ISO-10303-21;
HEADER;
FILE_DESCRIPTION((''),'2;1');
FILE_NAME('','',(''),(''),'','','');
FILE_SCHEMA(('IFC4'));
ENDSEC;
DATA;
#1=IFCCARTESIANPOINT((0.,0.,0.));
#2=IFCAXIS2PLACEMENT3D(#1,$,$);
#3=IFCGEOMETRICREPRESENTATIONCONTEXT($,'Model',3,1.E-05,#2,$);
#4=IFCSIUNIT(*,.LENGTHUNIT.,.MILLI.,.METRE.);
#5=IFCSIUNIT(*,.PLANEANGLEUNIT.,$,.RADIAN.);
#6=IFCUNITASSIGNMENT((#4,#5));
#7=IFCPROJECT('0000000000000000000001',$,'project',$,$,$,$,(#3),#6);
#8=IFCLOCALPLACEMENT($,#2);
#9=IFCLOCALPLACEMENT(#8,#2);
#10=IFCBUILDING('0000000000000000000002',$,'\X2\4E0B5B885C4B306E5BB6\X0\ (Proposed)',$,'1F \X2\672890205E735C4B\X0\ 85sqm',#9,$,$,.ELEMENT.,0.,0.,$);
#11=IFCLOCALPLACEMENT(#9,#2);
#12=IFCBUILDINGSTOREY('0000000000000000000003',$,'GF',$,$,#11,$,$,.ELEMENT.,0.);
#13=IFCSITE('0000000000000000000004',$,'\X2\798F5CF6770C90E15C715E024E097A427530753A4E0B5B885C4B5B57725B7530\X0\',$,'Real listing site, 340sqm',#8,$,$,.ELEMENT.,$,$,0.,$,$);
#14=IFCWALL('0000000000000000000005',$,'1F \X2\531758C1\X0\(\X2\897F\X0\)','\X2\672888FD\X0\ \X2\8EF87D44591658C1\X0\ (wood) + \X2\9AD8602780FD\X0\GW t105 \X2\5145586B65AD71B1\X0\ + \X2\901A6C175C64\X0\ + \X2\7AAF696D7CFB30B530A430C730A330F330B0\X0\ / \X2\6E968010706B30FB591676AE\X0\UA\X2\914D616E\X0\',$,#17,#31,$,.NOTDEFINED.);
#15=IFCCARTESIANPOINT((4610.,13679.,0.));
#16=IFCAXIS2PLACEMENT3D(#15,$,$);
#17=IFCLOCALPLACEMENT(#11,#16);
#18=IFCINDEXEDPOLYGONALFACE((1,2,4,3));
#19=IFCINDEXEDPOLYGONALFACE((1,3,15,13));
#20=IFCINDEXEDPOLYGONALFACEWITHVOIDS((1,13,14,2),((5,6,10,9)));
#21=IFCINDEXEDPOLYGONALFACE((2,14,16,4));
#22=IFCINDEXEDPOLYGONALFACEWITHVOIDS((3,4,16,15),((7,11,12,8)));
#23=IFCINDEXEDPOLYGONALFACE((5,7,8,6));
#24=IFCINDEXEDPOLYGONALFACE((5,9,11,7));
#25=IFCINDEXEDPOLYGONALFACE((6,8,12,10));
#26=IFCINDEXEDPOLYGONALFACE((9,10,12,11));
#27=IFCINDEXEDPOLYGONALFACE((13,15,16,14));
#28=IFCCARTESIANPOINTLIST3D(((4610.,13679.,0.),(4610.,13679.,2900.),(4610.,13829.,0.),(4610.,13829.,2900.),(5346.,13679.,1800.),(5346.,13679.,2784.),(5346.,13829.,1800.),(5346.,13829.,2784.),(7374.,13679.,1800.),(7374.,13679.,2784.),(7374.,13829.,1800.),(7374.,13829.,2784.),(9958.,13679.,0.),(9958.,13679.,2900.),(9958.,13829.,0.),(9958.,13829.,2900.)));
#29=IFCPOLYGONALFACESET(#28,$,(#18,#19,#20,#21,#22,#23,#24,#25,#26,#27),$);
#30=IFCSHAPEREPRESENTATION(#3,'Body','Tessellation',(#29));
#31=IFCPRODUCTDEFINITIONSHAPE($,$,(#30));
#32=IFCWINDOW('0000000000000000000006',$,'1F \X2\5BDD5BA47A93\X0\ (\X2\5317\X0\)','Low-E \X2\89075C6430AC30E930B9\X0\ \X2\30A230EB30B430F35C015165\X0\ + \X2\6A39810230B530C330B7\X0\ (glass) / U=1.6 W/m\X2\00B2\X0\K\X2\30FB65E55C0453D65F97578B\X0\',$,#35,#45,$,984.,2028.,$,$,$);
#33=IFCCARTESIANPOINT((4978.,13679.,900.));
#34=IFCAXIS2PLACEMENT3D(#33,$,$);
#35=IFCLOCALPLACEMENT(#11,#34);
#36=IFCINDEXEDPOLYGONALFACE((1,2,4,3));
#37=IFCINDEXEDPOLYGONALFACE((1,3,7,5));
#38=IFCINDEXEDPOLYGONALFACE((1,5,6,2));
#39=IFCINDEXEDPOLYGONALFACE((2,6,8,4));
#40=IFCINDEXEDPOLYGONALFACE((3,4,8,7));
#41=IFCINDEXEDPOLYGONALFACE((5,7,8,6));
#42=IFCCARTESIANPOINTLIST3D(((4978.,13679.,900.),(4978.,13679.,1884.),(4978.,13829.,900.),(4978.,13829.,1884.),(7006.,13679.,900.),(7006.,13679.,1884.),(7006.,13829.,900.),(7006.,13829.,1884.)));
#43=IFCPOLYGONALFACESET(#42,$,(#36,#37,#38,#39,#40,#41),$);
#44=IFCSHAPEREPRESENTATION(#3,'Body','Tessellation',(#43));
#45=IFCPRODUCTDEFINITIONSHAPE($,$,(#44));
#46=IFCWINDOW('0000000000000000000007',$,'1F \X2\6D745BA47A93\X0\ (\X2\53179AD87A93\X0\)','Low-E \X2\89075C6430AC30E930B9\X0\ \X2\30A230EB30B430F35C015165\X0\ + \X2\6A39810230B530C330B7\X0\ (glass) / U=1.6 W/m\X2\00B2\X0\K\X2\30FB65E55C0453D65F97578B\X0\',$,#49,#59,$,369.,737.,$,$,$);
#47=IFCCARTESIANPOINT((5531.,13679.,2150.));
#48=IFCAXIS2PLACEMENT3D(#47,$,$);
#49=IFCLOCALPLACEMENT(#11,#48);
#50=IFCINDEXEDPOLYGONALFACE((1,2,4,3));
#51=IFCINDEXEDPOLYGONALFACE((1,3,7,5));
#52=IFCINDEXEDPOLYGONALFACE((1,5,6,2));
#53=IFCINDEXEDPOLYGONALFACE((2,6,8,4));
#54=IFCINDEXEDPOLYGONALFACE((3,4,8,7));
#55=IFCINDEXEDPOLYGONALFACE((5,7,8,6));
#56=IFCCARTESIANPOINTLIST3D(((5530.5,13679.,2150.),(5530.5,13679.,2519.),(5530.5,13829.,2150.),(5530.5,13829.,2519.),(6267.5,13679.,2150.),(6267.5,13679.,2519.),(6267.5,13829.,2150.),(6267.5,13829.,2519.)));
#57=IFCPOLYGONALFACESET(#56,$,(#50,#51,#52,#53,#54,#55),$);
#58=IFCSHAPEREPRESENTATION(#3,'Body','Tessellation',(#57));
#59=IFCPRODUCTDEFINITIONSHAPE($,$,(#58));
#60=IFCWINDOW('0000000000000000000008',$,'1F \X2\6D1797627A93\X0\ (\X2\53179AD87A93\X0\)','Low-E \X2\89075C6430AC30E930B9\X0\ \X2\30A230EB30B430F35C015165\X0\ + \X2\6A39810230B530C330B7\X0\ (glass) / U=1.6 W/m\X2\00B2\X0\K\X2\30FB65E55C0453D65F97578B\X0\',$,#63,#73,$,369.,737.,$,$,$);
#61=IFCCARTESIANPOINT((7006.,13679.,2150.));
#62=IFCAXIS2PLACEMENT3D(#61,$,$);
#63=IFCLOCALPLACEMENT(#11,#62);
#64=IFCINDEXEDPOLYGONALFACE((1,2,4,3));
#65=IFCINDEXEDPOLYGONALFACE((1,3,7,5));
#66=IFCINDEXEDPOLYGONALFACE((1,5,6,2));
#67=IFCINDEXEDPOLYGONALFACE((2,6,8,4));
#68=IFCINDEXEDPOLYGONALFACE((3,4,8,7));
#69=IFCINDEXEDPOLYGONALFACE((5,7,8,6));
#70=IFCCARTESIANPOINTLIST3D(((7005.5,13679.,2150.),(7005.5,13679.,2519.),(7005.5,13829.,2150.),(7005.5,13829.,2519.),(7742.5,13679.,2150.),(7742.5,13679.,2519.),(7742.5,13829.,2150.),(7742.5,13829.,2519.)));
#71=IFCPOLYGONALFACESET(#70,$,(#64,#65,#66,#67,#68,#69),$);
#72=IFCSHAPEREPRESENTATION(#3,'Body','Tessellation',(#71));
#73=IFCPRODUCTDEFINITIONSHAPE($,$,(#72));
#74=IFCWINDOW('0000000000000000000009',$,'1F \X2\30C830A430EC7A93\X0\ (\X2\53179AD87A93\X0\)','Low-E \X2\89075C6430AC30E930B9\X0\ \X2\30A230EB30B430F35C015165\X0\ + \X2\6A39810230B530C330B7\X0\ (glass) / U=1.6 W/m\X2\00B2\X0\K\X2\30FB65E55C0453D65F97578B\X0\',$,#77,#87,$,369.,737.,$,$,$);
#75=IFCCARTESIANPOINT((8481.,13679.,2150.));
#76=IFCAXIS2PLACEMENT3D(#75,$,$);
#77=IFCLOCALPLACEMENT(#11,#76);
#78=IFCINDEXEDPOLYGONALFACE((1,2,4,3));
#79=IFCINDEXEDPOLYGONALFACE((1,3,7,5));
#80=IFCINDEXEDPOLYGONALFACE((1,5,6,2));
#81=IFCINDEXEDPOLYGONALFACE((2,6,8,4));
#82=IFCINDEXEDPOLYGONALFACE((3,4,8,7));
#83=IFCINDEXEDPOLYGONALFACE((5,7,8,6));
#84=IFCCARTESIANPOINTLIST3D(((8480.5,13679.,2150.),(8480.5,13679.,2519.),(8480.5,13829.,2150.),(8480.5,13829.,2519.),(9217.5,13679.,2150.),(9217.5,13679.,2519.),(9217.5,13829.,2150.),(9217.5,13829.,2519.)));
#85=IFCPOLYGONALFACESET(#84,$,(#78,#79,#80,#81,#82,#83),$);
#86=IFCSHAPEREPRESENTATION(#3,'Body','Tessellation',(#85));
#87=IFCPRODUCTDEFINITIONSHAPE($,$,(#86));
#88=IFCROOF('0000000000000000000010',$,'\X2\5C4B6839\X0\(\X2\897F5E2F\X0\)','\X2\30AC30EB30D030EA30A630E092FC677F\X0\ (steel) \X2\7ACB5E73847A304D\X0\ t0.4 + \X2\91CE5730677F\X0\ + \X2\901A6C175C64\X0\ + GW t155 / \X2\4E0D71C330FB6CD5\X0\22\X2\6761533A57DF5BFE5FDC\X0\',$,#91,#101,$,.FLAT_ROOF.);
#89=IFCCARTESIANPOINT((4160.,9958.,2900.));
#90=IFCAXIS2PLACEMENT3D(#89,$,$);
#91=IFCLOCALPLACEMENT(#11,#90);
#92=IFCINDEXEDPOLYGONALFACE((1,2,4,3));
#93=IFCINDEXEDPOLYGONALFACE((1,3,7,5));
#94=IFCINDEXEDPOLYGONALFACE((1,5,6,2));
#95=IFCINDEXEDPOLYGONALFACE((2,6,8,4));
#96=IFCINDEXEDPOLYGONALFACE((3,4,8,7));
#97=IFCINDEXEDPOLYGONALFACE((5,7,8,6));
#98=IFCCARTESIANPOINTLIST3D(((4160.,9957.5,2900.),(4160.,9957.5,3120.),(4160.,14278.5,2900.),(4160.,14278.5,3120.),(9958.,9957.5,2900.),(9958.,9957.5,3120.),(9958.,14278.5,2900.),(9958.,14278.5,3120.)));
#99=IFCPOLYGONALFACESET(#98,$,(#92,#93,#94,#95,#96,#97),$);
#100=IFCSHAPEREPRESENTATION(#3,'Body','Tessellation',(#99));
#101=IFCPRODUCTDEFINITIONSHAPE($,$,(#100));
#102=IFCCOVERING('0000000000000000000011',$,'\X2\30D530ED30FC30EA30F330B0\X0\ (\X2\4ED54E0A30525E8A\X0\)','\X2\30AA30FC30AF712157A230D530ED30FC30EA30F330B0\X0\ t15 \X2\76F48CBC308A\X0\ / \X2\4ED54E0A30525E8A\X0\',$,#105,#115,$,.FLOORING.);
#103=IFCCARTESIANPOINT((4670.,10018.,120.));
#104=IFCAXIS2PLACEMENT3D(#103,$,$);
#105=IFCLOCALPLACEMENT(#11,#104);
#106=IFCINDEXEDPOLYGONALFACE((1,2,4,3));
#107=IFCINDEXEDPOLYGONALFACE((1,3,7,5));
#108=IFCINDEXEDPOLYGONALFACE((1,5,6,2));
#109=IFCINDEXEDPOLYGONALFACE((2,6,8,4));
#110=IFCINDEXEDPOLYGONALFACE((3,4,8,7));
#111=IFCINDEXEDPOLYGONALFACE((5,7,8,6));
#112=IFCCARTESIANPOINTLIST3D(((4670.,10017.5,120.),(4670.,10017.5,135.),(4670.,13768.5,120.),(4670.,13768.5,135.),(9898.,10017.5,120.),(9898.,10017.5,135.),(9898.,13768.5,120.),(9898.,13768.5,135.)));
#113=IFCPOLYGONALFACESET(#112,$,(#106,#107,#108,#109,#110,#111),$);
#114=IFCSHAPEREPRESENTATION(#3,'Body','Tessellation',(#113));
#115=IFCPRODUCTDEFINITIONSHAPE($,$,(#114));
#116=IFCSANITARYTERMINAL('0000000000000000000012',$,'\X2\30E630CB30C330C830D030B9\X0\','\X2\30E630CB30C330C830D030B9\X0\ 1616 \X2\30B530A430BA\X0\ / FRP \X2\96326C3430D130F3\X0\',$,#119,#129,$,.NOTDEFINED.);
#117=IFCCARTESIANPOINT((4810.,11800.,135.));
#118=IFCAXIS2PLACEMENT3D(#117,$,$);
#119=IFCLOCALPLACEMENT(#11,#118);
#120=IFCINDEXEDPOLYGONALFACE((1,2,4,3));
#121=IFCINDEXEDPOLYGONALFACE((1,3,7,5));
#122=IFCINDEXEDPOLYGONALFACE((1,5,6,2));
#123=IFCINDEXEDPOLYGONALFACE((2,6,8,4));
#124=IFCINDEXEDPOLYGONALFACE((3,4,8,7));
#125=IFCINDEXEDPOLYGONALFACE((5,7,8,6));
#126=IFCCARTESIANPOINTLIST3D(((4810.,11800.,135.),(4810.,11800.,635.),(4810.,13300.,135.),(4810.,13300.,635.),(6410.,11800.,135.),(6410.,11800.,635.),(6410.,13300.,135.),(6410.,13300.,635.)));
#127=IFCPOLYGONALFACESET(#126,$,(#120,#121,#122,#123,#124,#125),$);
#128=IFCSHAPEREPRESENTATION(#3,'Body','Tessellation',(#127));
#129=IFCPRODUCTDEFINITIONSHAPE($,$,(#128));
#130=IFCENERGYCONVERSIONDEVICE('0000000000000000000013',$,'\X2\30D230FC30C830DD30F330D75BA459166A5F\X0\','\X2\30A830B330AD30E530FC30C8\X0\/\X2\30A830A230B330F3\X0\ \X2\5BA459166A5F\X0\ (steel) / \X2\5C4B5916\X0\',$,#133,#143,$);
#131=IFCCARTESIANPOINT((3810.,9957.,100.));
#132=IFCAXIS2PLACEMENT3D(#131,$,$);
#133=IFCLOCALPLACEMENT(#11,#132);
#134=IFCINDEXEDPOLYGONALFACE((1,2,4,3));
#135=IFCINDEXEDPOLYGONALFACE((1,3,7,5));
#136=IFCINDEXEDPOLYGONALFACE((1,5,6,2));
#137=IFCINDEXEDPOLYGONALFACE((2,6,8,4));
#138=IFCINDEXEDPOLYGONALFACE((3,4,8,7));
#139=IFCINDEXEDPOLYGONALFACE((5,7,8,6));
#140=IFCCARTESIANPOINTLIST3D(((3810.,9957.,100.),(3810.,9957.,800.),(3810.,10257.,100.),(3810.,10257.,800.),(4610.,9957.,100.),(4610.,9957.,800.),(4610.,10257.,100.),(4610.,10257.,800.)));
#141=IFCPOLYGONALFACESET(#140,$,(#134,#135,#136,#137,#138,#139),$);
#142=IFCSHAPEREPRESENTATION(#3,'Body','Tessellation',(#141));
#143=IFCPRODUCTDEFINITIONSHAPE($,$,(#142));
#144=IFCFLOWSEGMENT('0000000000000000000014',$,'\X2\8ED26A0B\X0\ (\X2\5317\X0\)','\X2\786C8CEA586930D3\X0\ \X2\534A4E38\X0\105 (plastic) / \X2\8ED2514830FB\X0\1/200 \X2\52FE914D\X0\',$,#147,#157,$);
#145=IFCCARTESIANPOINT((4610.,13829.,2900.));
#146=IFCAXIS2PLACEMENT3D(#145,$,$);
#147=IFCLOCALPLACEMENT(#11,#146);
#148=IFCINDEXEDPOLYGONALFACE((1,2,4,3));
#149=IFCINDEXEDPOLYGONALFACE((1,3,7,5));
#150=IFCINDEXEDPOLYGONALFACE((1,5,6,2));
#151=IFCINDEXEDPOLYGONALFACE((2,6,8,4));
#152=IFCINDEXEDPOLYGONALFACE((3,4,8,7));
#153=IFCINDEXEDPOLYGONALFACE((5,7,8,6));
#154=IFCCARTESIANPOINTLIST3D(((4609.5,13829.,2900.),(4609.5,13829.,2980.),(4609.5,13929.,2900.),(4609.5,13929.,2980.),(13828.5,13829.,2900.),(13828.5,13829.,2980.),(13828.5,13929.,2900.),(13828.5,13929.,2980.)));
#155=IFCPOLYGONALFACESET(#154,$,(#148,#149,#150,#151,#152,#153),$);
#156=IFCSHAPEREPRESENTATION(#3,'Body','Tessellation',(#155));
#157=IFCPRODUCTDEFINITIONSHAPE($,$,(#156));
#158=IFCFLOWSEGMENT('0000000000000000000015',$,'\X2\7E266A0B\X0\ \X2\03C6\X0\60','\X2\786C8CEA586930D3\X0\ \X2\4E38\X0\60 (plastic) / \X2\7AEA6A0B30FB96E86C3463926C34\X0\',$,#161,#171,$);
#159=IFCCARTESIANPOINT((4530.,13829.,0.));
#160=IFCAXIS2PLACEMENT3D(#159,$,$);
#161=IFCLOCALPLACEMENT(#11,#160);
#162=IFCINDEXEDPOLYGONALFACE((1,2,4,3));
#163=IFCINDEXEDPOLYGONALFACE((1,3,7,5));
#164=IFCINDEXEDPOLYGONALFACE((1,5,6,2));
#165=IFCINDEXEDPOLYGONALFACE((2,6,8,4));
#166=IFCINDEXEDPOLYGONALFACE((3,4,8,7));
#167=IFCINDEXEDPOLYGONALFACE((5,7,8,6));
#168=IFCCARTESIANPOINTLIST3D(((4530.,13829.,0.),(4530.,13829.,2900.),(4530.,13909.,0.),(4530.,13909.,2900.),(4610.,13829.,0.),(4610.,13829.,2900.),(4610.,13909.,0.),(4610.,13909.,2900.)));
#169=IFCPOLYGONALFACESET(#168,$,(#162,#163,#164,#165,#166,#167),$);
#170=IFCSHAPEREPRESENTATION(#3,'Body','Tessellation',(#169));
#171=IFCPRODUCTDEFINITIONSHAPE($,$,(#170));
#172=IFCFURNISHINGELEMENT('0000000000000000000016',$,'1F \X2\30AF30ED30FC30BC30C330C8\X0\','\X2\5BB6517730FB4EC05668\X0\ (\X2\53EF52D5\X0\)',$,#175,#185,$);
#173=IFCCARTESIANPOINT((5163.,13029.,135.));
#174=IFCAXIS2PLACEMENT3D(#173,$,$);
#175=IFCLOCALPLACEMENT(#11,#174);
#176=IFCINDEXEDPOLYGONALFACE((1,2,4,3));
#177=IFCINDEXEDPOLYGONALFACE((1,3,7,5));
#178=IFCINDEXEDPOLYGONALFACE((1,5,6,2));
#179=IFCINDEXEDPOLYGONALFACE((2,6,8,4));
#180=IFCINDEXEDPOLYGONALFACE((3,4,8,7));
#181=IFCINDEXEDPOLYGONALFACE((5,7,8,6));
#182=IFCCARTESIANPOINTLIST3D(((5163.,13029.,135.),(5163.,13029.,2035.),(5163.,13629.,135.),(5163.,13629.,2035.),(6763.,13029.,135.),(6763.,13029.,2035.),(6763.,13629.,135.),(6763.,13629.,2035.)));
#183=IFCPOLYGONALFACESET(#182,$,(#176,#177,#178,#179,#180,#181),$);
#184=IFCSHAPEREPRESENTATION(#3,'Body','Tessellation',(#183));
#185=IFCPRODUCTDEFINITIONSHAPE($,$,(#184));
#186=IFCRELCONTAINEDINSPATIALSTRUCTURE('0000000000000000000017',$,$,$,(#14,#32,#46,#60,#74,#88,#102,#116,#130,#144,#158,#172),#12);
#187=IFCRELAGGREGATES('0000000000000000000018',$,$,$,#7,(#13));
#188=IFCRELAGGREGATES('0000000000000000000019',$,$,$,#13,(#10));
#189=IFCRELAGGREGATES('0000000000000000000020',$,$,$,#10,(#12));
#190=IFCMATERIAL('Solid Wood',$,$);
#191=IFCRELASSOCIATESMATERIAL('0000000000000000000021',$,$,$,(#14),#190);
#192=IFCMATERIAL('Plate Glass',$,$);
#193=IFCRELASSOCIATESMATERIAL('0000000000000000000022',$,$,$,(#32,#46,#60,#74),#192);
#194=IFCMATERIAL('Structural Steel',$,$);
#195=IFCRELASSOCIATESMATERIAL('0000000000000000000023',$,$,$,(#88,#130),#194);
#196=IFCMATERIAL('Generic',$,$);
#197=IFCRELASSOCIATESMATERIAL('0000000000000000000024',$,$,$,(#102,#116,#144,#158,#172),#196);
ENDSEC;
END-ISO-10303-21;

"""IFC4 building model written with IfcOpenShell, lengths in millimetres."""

from ifc_helpers import new_model, si_unit, frame, frame_2d, origin, place, context, project, spatial, rectangle, extrude, material, element, fill, save


model = new_model("IFC4")

# Units and contexts
model_context = context("Model", 3, precision=1e-05, world=origin())
ifc_project = project(units=[si_unit("LENGTHUNIT", "METRE", prefix="MILLI"), si_unit("PLANEANGLEUNIT", "RADIAN")], contexts=[model_context])

# Site, building, storey
site_placement = place(None, origin())
site = spatial("IfcSite", under=ifc_project, at=site_placement, Name="福島県郡山市三穂田町下守屋字牛田", ObjectType="Real listing site, 340sqm", CompositionType="ELEMENT", RefElevation=0.0)
building_placement = place(site_placement, origin())
building = spatial("IfcBuilding", under=site, at=building_placement, Name="下守屋の家 (Proposed)", ObjectType="1F 木造平屋 85sqm", CompositionType="ELEMENT", ElevationOfRefHeight=0.0, ElevationOfTerrain=0.0)
storey_placement = place(building_placement, origin())
storey = spatial("IfcBuildingStorey", under=building, at=storey_placement, Name="GF", CompositionType="ELEMENT", Elevation=0.0)

# Shared definitions
ifc_material_1 = material(Name="Solid Wood")

# Wall, openings, windows
wall_1_placement = place(storey_placement, frame((4610.0, 13679.0, 0.0)))
wall_1 = element("IfcWall", 1, at=wall_1_placement, inside=storey, material=ifc_material_1, Name="1F 北壁(西)", Description="木製 軸組外壁 (wood) + 高性能GW t105 充填断熱 + 通気層 + 窯業系サイディング / 準耐火・外皮UA配慮", PredefinedType="NOTDEFINED", context=model_context, shape_type="SweptSolid", body=[
    extrude(rectangle(XDim=5348.0, YDim=150.0, at=frame_2d((2674.0, 75.0))), frame((4610.0, 13679.0, 0.0)), (0.0, 0.0, 1.0), 2900.0),
])
opening_1_placement = place(storey_placement, frame((4978.0, 13679.0, 900.0)))
opening_1 = element("IfcOpeningElement", 2, at=opening_1_placement, cuts=wall_1, PredefinedType="NOTDEFINED", context=model_context, shape_type="SweptSolid", body=[
    extrude(rectangle(XDim=2028.0, YDim=150.0, at=frame_2d((1014.0, 75.0))), frame((4978.0, 13679.0, 900.0)), (0.0, 0.0, 1.0), 984.0),
])
opening_2_placement = place(storey_placement, frame((5531.0, 13679.0, 2150.0)))
opening_2 = element("IfcOpeningElement", 3, at=opening_2_placement, cuts=wall_1, PredefinedType="NOTDEFINED", context=model_context, shape_type="SweptSolid", body=[
    extrude(rectangle(XDim=737.0, YDim=150.0, at=frame_2d((368.0, 75.0))), frame((5531.0, 13679.0, 2150.0)), (0.0, 0.0, 1.0), 369.0),
])
opening_3_placement = place(storey_placement, frame((7006.0, 13679.0, 2150.0)))
opening_3 = element("IfcOpeningElement", 4, at=opening_3_placement, cuts=wall_1, PredefinedType="NOTDEFINED", context=model_context, shape_type="SweptSolid", body=[
    extrude(rectangle(XDim=737.0, YDim=150.0, at=frame_2d((368.0, 75.0))), frame((7006.0, 13679.0, 2150.0)), (0.0, 0.0, 1.0), 369.0),
])
opening_4_placement = place(storey_placement, frame((8481.0, 13679.0, 2150.0)))
opening_4 = element("IfcOpeningElement", 5, at=opening_4_placement, cuts=wall_1, PredefinedType="NOTDEFINED", context=model_context, shape_type="SweptSolid", body=[
    extrude(rectangle(XDim=737.0, YDim=150.0, at=frame_2d((368.0, 75.0))), frame((8481.0, 13679.0, 2150.0)), (0.0, 0.0, 1.0), 369.0),
])
ifc_material_2 = material(Name="Plate Glass")
window_1_placement = place(storey_placement, frame((4978.0, 13679.0, 900.0)))
window_1 = element("IfcWindow", 6, at=window_1_placement, inside=storey, material=ifc_material_2, Name="1F 寝室窓 (北)", Description="Low-E 複層ガラス アルゴン封入 + 樹脂サッシ (glass) / U=1.6 W/m²K・日射取得型", OverallHeight=984.0, OverallWidth=2028.0, context=model_context, shape_type="SweptSolid", body=[
    extrude(rectangle(XDim=2028.0, YDim=150.0, at=frame_2d((1014.0, 75.0))), frame((4978.0, 13679.0, 900.0)), (0.0, 0.0, 1.0), 984.0),
])
fill(opening_1, window_1)
window_2_placement = place(storey_placement, frame((5531.0, 13679.0, 2150.0)))
window_2 = element("IfcWindow", 7, at=window_2_placement, inside=storey, material=ifc_material_2, Name="1F 浴室窓 (北高窓)", Description="Low-E 複層ガラス アルゴン封入 + 樹脂サッシ (glass) / U=1.6 W/m²K・日射取得型", OverallHeight=369.0, OverallWidth=737.0, context=model_context, shape_type="SweptSolid", body=[
    extrude(rectangle(XDim=737.0, YDim=150.0, at=frame_2d((368.0, 75.0))), frame((5531.0, 13679.0, 2150.0)), (0.0, 0.0, 1.0), 369.0),
])
fill(opening_2, window_2)
window_3_placement = place(storey_placement, frame((7006.0, 13679.0, 2150.0)))
window_3 = element("IfcWindow", 8, at=window_3_placement, inside=storey, material=ifc_material_2, Name="1F 洗面窓 (北高窓)", Description="Low-E 複層ガラス アルゴン封入 + 樹脂サッシ (glass) / U=1.6 W/m²K・日射取得型", OverallHeight=369.0, OverallWidth=737.0, context=model_context, shape_type="SweptSolid", body=[
    extrude(rectangle(XDim=737.0, YDim=150.0, at=frame_2d((368.0, 75.0))), frame((7006.0, 13679.0, 2150.0)), (0.0, 0.0, 1.0), 369.0),
])
fill(opening_3, window_3)
window_4_placement = place(storey_placement, frame((8481.0, 13679.0, 2150.0)))
window_4 = element("IfcWindow", 9, at=window_4_placement, inside=storey, material=ifc_material_2, Name="1F トイレ窓 (北高窓)", Description="Low-E 複層ガラス アルゴン封入 + 樹脂サッシ (glass) / U=1.6 W/m²K・日射取得型", OverallHeight=369.0, OverallWidth=737.0, context=model_context, shape_type="SweptSolid", body=[
    extrude(rectangle(XDim=737.0, YDim=150.0, at=frame_2d((368.0, 75.0))), frame((8481.0, 13679.0, 2150.0)), (0.0, 0.0, 1.0), 369.0),
])
fill(opening_4, window_4)

# Roof
ifc_material_3 = material(Name="Structural Steel")
roof_placement = place(storey_placement, frame((4160.0, 9958.0, 2900.0)))
element("IfcRoof", 10, at=roof_placement, inside=storey, material=ifc_material_3, Name="屋根(西帯)", Description="ガルバリウム鋼板 (steel) 立平葺き t0.4 + 野地板 + 通気層 + GW t155 / 不燃・法22条区域対応", PredefinedType="FLAT_ROOF", context=model_context, shape_type="SweptSolid", body=[
    extrude(rectangle(XDim=5798.0, YDim=4321.0, at=frame_2d((2899.0, 2160.0))), frame((4160.0, 9958.0, 2900.0)), (0.0, 0.0, 1.0), 220.0),
])

# Covering
ifc_material_4 = material(Name="Generic")
covering_placement = place(storey_placement, frame((4670.0, 10018.0, 120.0)))
element("IfcCovering", 11, at=covering_placement, inside=storey, material=ifc_material_4, Name="フローリング (仕上げ床)", Description="オーク無垢フローリング t15 直貼り / 仕上げ床", PredefinedType="FLOORING", context=model_context, shape_type="SweptSolid", body=[
    extrude(rectangle(XDim=5228.0, YDim=3751.0, at=frame_2d((2614.0, 1875.0))), frame((4670.0, 10018.0, 120.0)), (0.0, 0.0, 1.0), 15.0),
])

# Sanitary terminal
sanitary_terminal_placement = place(storey_placement, frame((4810.0, 11800.0, 135.0)))
element("IfcSanitaryTerminal", 12, at=sanitary_terminal_placement, inside=storey, material=ifc_material_4, Name="ユニットバス", Description="ユニットバス 1616 サイズ / FRP 防水パン", PredefinedType="NOTDEFINED", context=model_context, shape_type="SweptSolid", body=[
    extrude(rectangle(XDim=1600.0, YDim=1500.0, at=frame_2d((800.0, 750.0))), frame((4810.0, 11800.0, 135.0)), (0.0, 0.0, 1.0), 500.0),
])

# Energy conversion device
energy_conversion_device_placement = place(storey_placement, frame((3810.0, 9957.0, 100.0)))
element("IfcEnergyConversionDevice", 13, at=energy_conversion_device_placement, inside=storey, material=ifc_material_3, Name="ヒートポンプ室外機", Description="エコキュート/エアコン 室外機 (steel) / 屋外", context=model_context, shape_type="SweptSolid", body=[
    extrude(rectangle(XDim=800.0, YDim=300.0, at=frame_2d((400.0, 150.0))), frame((3810.0, 9957.0, 100.0)), (0.0, 0.0, 1.0), 700.0),
])

# Flow segments
flow_segment_1_placement = place(storey_placement, frame((4610.0, 13829.0, 2900.0)))
element("IfcFlowSegment", 14, at=flow_segment_1_placement, inside=storey, material=ifc_material_4, Name="軒樋 (北)", Description="硬質塩ビ 半丸105 (plastic) / 軒先・1/200 勾配", context=model_context, shape_type="SweptSolid", body=[
    extrude(rectangle(XDim=9219.0, YDim=100.0, at=frame_2d((4609.0, 50.0))), frame((4610.0, 13829.0, 2900.0)), (0.0, 0.0, 1.0), 80.0),
])
flow_segment_2_placement = place(storey_placement, frame((4530.0, 13829.0, 0.0)))
element("IfcFlowSegment", 15, at=flow_segment_2_placement, inside=storey, material=ifc_material_4, Name="縦樋 φ60", Description="硬質塩ビ 丸60 (plastic) / 竪樋・雨水排水", context=model_context, shape_type="SweptSolid", body=[
    extrude(rectangle(XDim=80.0, YDim=80.0, at=frame_2d((40.0, 40.0))), frame((4530.0, 13829.0, 0.0)), (0.0, 0.0, 1.0), 2900.0),
])

# Furnishing element
furnishing_1_placement = place(storey_placement, frame((5163.0, 13029.0, 135.0)))
element("IfcFurnishingElement", 16, at=furnishing_1_placement, inside=storey, material=ifc_material_4, Name="1F クローゼット", Description="家具・什器 (可動)", context=model_context, shape_type="SweptSolid", body=[
    extrude(rectangle(XDim=1600.0, YDim=600.0, at=frame_2d((800.0, 300.0))), frame((5163.0, 13029.0, 135.0)), (0.0, 0.0, 1.0), 1900.0),
])

save(model, "model.ifc")
